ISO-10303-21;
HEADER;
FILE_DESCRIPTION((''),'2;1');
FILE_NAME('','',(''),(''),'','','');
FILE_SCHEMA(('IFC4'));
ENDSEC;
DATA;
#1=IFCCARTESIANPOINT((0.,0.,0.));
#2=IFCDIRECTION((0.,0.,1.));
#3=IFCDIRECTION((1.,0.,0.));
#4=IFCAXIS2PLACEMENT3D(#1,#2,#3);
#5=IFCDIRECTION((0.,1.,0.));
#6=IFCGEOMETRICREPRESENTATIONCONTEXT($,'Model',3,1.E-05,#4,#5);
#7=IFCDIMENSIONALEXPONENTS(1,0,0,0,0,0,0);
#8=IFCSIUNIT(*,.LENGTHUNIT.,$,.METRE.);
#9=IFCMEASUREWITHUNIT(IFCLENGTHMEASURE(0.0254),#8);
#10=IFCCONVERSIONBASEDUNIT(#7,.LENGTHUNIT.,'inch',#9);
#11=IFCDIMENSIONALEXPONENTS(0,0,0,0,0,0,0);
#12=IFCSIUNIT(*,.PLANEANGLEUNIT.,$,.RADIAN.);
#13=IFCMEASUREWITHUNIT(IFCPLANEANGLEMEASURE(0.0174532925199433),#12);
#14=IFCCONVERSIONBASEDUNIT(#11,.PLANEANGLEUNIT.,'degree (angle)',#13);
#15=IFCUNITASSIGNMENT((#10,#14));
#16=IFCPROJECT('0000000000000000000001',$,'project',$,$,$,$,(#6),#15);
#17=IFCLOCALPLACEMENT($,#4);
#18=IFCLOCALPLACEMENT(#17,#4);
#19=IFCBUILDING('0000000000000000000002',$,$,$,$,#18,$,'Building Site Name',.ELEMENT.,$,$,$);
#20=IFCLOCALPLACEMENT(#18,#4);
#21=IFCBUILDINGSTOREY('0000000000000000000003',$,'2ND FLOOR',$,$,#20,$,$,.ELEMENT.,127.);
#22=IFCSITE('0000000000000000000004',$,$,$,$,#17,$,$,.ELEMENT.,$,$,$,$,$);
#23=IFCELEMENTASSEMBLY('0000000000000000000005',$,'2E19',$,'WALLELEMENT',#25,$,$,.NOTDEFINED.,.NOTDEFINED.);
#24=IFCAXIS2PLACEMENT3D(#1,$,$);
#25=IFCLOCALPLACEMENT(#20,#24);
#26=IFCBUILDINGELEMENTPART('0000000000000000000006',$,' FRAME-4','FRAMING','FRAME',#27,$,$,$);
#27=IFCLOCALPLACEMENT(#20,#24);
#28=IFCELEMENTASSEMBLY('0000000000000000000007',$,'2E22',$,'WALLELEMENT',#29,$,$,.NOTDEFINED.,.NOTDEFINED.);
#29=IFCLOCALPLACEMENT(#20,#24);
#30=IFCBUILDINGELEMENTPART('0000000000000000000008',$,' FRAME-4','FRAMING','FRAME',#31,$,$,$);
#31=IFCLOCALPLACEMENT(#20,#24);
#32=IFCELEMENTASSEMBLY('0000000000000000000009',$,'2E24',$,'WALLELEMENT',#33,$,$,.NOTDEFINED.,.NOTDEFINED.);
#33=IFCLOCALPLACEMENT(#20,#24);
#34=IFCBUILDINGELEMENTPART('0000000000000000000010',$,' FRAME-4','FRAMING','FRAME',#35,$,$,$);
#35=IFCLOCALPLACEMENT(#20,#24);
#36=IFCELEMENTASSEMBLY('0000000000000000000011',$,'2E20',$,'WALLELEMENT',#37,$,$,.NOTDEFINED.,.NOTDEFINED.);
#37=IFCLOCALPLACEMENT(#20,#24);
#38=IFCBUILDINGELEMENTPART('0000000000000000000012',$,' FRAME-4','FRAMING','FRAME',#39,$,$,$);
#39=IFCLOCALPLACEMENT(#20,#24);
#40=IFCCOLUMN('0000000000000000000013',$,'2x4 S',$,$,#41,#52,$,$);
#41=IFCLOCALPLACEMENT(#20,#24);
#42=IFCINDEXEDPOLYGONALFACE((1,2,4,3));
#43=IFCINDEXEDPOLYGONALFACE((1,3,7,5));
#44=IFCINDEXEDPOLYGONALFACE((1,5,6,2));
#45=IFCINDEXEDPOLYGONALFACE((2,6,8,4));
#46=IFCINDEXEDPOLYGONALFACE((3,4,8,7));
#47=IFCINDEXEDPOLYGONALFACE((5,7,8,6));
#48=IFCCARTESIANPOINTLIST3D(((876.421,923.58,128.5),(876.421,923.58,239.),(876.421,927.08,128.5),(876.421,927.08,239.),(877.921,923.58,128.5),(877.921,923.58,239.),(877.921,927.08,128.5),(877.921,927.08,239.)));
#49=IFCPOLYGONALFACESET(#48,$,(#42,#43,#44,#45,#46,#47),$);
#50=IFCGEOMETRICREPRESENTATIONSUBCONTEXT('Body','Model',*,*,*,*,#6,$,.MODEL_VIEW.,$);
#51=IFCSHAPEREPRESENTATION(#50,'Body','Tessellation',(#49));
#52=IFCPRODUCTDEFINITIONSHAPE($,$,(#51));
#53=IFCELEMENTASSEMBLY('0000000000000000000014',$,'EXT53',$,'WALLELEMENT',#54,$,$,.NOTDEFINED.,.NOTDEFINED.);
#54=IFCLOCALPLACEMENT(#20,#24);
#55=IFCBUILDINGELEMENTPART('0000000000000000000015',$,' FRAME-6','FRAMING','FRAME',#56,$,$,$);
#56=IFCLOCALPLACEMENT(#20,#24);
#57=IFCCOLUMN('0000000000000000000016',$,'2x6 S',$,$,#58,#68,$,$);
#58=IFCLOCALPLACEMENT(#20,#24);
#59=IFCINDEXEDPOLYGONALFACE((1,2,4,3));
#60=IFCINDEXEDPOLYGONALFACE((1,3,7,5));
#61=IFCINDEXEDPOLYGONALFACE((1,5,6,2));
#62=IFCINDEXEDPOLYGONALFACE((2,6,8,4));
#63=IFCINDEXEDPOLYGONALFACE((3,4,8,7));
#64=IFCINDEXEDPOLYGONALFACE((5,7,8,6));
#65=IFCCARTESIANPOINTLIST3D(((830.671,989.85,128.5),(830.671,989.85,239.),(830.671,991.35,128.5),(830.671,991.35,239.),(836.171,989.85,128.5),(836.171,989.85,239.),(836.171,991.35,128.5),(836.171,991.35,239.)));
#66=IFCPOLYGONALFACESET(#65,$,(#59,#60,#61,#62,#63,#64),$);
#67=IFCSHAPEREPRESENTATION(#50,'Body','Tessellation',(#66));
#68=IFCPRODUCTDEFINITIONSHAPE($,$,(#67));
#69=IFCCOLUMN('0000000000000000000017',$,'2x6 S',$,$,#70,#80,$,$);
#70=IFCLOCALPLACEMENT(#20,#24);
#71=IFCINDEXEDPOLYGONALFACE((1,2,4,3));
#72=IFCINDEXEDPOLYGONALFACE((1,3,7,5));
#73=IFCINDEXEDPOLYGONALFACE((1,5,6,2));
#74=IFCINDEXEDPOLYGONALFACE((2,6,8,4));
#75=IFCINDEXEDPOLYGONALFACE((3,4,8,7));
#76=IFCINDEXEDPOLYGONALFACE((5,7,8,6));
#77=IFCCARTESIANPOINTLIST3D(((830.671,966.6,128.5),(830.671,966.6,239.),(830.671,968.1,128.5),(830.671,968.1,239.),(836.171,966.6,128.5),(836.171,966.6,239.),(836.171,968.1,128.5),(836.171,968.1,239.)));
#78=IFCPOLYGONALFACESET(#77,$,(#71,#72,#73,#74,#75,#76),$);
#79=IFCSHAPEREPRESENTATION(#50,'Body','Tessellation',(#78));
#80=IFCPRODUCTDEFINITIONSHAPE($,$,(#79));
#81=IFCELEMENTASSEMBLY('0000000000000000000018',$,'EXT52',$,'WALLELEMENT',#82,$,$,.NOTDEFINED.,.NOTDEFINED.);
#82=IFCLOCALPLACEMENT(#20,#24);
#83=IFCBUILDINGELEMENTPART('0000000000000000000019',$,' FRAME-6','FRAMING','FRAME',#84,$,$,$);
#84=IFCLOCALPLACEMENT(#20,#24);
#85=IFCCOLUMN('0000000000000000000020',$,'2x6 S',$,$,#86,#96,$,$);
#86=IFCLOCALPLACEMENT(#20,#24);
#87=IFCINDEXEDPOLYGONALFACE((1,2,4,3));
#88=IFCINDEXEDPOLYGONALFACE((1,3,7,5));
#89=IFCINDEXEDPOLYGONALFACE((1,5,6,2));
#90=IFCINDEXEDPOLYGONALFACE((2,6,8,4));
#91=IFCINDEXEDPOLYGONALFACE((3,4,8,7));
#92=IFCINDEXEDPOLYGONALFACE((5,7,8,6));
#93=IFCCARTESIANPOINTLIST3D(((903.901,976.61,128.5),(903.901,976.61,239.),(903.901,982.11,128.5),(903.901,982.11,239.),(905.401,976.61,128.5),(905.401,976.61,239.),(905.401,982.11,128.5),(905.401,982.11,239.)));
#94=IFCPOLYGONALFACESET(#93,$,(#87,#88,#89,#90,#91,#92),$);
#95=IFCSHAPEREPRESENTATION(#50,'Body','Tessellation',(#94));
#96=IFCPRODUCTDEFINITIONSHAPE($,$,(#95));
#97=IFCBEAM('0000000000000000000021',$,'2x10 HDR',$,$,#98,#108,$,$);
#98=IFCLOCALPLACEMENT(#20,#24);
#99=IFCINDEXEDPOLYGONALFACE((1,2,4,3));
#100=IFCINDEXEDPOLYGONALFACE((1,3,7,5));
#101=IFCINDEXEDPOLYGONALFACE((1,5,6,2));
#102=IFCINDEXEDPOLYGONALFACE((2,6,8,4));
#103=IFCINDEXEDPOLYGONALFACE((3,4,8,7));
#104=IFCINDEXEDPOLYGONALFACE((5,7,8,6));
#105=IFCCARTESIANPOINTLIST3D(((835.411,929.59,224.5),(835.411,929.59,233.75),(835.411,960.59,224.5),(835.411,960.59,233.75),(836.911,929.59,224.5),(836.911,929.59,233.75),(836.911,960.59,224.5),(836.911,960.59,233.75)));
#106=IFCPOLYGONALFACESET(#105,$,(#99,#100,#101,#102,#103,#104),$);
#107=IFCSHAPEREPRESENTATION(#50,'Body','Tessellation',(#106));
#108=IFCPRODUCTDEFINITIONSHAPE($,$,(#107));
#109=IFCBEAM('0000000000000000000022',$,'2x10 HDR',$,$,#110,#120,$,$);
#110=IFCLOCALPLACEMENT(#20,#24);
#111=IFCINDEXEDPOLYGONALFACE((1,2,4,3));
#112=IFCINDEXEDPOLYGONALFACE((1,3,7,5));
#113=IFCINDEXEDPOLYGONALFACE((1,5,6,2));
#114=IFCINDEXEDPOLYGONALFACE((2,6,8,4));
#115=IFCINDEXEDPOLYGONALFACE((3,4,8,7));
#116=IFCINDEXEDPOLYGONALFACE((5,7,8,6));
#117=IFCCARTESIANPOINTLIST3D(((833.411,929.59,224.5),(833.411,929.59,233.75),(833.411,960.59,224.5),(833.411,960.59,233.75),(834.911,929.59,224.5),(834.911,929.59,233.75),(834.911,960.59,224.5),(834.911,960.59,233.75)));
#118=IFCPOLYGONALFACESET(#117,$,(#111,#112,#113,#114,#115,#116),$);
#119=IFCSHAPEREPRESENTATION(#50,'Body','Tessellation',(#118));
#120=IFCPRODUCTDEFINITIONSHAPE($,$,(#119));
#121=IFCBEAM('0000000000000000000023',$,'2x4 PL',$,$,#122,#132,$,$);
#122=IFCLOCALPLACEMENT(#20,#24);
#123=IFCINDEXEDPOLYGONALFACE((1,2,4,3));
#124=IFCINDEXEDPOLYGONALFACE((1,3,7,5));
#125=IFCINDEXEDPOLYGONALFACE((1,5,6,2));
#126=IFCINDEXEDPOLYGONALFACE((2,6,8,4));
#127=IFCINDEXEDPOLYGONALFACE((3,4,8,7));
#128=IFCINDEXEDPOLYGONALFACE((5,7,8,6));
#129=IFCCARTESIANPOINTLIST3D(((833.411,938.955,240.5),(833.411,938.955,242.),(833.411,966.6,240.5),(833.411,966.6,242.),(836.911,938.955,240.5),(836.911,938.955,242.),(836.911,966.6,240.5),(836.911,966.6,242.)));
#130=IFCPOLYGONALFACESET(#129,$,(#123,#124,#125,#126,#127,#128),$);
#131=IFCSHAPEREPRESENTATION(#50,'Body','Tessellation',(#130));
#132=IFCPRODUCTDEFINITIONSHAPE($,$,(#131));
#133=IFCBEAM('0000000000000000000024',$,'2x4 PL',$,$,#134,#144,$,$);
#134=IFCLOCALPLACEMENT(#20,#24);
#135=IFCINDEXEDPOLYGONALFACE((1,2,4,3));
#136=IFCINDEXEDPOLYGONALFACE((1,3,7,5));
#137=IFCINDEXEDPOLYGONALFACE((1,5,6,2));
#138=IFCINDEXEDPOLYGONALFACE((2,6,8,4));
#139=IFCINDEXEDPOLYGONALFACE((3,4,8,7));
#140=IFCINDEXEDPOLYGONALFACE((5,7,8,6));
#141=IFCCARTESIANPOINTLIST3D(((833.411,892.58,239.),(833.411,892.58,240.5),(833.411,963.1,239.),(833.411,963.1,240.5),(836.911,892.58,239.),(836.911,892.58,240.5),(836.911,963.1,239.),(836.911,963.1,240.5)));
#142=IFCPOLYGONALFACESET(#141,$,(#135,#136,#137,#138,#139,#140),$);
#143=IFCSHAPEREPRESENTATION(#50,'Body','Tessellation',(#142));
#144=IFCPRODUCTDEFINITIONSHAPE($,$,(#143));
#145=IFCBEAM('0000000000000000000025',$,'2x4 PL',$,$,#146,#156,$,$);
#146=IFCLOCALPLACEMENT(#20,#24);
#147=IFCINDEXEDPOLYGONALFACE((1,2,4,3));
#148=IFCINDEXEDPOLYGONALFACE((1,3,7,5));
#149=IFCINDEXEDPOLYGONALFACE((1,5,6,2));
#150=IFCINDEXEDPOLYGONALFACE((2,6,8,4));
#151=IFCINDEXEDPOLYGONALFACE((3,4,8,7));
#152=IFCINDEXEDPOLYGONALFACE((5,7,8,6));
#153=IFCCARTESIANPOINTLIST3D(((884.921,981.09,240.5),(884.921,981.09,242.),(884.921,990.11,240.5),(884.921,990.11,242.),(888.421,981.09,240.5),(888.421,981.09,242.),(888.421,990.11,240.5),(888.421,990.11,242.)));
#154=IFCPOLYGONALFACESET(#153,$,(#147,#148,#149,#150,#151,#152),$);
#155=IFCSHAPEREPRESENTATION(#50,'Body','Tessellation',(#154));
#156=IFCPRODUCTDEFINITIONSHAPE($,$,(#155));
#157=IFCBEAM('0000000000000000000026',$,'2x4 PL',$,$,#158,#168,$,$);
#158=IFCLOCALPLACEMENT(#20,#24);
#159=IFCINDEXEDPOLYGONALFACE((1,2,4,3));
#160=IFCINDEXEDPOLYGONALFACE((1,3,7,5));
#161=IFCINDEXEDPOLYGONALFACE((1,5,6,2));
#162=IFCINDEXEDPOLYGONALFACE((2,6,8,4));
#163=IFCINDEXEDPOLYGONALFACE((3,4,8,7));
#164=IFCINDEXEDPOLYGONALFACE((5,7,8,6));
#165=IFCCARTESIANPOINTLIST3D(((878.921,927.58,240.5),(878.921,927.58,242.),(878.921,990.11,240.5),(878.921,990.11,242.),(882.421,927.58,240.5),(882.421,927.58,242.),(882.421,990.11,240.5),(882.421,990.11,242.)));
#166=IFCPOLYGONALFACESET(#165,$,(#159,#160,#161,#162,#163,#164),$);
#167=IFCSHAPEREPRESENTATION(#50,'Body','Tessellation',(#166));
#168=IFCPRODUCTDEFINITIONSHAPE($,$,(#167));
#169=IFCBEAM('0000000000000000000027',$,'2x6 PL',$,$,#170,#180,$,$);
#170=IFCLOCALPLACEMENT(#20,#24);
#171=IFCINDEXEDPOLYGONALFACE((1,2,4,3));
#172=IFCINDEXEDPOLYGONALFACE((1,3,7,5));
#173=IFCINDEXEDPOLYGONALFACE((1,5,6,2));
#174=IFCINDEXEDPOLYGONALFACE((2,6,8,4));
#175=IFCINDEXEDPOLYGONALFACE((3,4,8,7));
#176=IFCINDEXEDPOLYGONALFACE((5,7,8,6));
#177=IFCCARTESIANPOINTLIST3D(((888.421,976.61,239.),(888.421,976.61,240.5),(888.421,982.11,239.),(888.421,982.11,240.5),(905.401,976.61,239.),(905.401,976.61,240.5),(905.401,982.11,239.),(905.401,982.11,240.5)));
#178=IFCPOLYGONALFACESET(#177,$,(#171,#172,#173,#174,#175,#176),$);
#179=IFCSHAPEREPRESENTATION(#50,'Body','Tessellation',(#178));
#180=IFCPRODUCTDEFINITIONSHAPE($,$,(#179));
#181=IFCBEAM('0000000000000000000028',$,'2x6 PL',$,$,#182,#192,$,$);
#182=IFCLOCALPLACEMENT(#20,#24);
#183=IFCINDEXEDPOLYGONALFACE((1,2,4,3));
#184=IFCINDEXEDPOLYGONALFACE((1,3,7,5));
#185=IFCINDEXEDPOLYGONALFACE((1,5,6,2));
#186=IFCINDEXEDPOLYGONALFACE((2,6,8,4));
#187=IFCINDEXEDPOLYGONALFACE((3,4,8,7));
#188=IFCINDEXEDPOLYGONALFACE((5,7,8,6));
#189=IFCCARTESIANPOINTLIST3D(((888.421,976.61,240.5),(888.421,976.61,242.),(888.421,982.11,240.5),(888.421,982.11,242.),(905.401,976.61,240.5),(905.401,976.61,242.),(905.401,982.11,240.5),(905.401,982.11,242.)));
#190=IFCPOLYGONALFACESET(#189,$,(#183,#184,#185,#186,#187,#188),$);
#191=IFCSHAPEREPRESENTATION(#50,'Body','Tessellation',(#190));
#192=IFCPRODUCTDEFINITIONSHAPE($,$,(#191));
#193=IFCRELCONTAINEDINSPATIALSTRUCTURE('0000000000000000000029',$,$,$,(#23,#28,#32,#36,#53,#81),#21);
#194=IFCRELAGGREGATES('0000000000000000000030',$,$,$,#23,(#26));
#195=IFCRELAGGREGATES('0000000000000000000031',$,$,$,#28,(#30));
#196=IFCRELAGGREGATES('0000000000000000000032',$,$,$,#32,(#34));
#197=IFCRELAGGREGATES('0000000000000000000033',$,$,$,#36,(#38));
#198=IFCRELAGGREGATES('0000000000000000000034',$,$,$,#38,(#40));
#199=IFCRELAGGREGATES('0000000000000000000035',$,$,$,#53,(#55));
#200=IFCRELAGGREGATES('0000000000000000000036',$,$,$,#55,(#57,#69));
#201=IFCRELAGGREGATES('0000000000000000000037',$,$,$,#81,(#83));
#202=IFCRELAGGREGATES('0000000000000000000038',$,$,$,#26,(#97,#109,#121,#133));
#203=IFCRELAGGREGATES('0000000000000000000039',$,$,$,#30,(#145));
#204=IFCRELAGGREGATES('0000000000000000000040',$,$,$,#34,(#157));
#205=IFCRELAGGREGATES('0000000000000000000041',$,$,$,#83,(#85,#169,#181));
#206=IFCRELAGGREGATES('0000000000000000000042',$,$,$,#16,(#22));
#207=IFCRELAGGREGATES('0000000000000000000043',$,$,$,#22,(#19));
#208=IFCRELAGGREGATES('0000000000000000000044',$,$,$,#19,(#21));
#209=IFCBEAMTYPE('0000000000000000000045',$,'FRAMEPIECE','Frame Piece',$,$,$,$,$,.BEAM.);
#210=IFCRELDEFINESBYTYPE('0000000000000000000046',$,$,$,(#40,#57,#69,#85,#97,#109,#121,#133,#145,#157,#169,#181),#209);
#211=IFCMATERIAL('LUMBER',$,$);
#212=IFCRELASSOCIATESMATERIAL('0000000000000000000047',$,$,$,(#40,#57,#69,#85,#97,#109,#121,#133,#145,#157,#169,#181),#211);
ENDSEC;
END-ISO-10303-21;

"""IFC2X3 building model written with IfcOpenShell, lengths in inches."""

from ifc_helpers import new_model, entity, si_unit, converted_unit, direction, frame, frame_2d, origin_with_axes, place, context, subcontext, project, spatial, rectangle, extrude, material, type_object, element, aggregate, save


model = new_model("IFC2X3")

# Units and contexts
model_context = context("Model", 3, precision=1e-05, world=origin_with_axes(), true_north=direction((0.0, 1.0, 0.0)))
body_context = subcontext(model_context, "Body", "Model", "MODEL_VIEW")
ifc_project = project(units=[converted_unit("LENGTHUNIT", "inch", entity("IfcLengthMeasure", 0.0254), si_unit("LENGTHUNIT", "METRE"), dimensions=[1, 0, 0, 0, 0, 0, 0]), converted_unit("PLANEANGLEUNIT", "degree (angle)", entity("IfcPlaneAngleMeasure", 0.0174532925199433), si_unit("PLANEANGLEUNIT", "RADIAN"), dimensions=[0, 0, 0, 0, 0, 0, 0])], contexts=[model_context])

# Site, building, storey
site_placement = place(None, origin_with_axes())
site = spatial("IfcSite", under=ifc_project, at=site_placement, CompositionType="ELEMENT")
building_placement = place(site_placement, origin_with_axes())
building = spatial("IfcBuilding", under=site, at=building_placement, LongName="Building Site Name", CompositionType="ELEMENT")
storey_placement = place(building_placement, origin_with_axes())
storey = spatial("IfcBuildingStorey", under=building, at=storey_placement, Name="2ND FLOOR", CompositionType="ELEMENT", Elevation=127.0)

# Element assembly, building element part
assembly_1_placement = place(storey_placement, origin_with_axes())
assembly_1 = element("IfcElementAssembly", 1, at=assembly_1_placement, inside=storey, Name="2E19", ObjectType="WALLELEMENT", AssemblyPlace="NOTDEFINED", PredefinedType="NOTDEFINED")
building_element_part_1 = element("IfcBuildingElementPart", 2, Name=" FRAME-4", Description="FRAMING", ObjectType="FRAME")
aggregate(assembly_1, [building_element_part_1])
ifc_material = material(Name="LUMBER")
beam_type = type_object("IfcBeamType", Name="FRAMEPIECE", Description="Frame Piece", PredefinedType="BEAM")

# Element assembly, building element part
assembly_2_placement = place(storey_placement, origin_with_axes())
assembly_2 = element("IfcElementAssembly", 3, at=assembly_2_placement, inside=storey, Name="2E22", ObjectType="WALLELEMENT", AssemblyPlace="NOTDEFINED", PredefinedType="NOTDEFINED")
building_element_part_2 = element("IfcBuildingElementPart", 4, Name=" FRAME-4", Description="FRAMING", ObjectType="FRAME")
aggregate(assembly_2, [building_element_part_2])

# Element assemblies, building element parts, columns
assembly_3_placement = place(storey_placement, origin_with_axes())
assembly_3 = element("IfcElementAssembly", 5, at=assembly_3_placement, inside=storey, Name="2E24", ObjectType="WALLELEMENT", AssemblyPlace="NOTDEFINED", PredefinedType="NOTDEFINED")
building_element_part_3 = element("IfcBuildingElementPart", 6, Name=" FRAME-4", Description="FRAMING", ObjectType="FRAME")
aggregate(assembly_3, [building_element_part_3])
assembly_4_placement = place(storey_placement, origin_with_axes())
assembly_4 = element("IfcElementAssembly", 7, at=assembly_4_placement, inside=storey, Name="2E20", ObjectType="WALLELEMENT", AssemblyPlace="NOTDEFINED", PredefinedType="NOTDEFINED")
building_element_part_4 = element("IfcBuildingElementPart", 8, Name=" FRAME-4", Description="FRAMING", ObjectType="FRAME")
aggregate(assembly_4, [building_element_part_4])
column_1_placement = place(assembly_4_placement, frame((877.171, 925.33, 239.0), z_axis=(0.0, 0.0, -1.0), x_axis=(-1.0, 0.0, 0.0)))
column_1 = element("IfcColumn", 9, at=column_1_placement, type_object=beam_type, material=ifc_material, Name="2x4 S", context=body_context, shape_type="SweptSolid", body=[
    extrude(rectangle(XDim=1.5, YDim=3.5, at=frame_2d((0.0, 0.0), x_axis=(-1.0, 0.0))), origin_with_axes(), (0.0, 0.0, 1.0), 110.5),
])
aggregate(building_element_part_4, [column_1])
assembly_5_placement = place(storey_placement, origin_with_axes())
assembly_5 = element("IfcElementAssembly", 10, at=assembly_5_placement, inside=storey, Name="EXT53", ObjectType="WALLELEMENT", AssemblyPlace="NOTDEFINED", PredefinedType="NOTDEFINED")
building_element_part_5 = element("IfcBuildingElementPart", 11, Name=" FRAME-6", Description="FRAMING", ObjectType="FRAME")
aggregate(assembly_5, [building_element_part_5])
column_2_placement = place(assembly_5_placement, frame((833.421, 990.6, 239.0), z_axis=(0.0, 0.0, -1.0), x_axis=(0.0, 1.0, 0.0)))
column_2 = element("IfcColumn", 12, at=column_2_placement, type_object=beam_type, material=ifc_material, Name="2x6 S", context=body_context, shape_type="SweptSolid", body=[
    extrude(rectangle(XDim=1.5, YDim=5.5, at=frame_2d((0.0, 0.0), x_axis=(-1.0, 0.0))), origin_with_axes(), (0.0, 0.0, 1.0), 110.5),
])
column_3_placement = place(assembly_5_placement, frame((833.421, 967.35, 239.0), z_axis=(0.0, 0.0, -1.0), x_axis=(0.0, 1.0, 0.0)))
column_3 = element("IfcColumn", 13, at=column_3_placement, type_object=beam_type, material=ifc_material, Name="2x6 S", context=body_context, shape_type="SweptSolid", body=[
    extrude(rectangle(XDim=1.5, YDim=5.5, at=frame_2d((0.0, 0.0), x_axis=(-1.0, 0.0))), origin_with_axes(), (0.0, 0.0, 1.0), 110.5),
])
aggregate(building_element_part_5, [column_2, column_3])

# Element assembly, building element part, column
assembly_6_placement = place(storey_placement, origin_with_axes())
assembly_6 = element("IfcElementAssembly", 14, at=assembly_6_placement, inside=storey, Name="EXT52", ObjectType="WALLELEMENT", AssemblyPlace="NOTDEFINED", PredefinedType="NOTDEFINED")
building_element_part_6 = element("IfcBuildingElementPart", 15, Name=" FRAME-6", Description="FRAMING", ObjectType="FRAME")
aggregate(assembly_6, [building_element_part_6])
column_4_placement = place(assembly_6_placement, frame((904.651, 979.36, 239.0), z_axis=(0.0, 0.0, -1.0), x_axis=(-1.0, 0.0, 0.0)))
column_4 = element("IfcColumn", 16, at=column_4_placement, type_object=beam_type, material=ifc_material, Name="2x6 S", context=body_context, shape_type="SweptSolid", body=[
    extrude(rectangle(XDim=1.5, YDim=5.5, at=frame_2d((0.0, 0.0), x_axis=(-1.0, 0.0))), origin_with_axes(), (0.0, 0.0, 1.0), 110.5),
])

# Beams
beam_1_placement = place(assembly_1_placement, frame((836.161, 929.59, 229.125), z_axis=(0.0, 1.0, 0.0), x_axis=(-1.0, 0.0, 0.0)))
beam_1 = element("IfcBeam", 17, at=beam_1_placement, type_object=beam_type, material=ifc_material, Name="2x10 HDR", context=body_context, shape_type="SweptSolid", body=[
    extrude(rectangle(XDim=1.5, YDim=9.25, at=frame_2d((0.0, 0.0), x_axis=(-1.0, 0.0))), origin_with_axes(), (0.0, 0.0, 1.0), 31.0),
])
beam_2_placement = place(assembly_1_placement, frame((834.161, 929.59, 229.125), z_axis=(0.0, 1.0, 0.0), x_axis=(-1.0, 0.0, 0.0)))
beam_2 = element("IfcBeam", 18, at=beam_2_placement, type_object=beam_type, material=ifc_material, Name="2x10 HDR", context=body_context, shape_type="SweptSolid", body=[
    extrude(rectangle(XDim=1.5, YDim=9.25, at=frame_2d((0.0, 0.0), x_axis=(-1.0, 0.0))), origin_with_axes(), (0.0, 0.0, 1.0), 31.0),
])
beam_3_placement = place(assembly_1_placement, frame((835.161, 966.6, 241.25), z_axis=(0.0, -1.0, 0.0), x_axis=(0.0, 0.0, -1.0)))
beam_3 = element("IfcBeam", 19, at=beam_3_placement, type_object=beam_type, material=ifc_material, Name="2x4 PL", context=body_context, shape_type="SweptSolid", body=[
    extrude(rectangle(XDim=1.5, YDim=3.5, at=frame_2d((0.0, 0.0), x_axis=(-1.0, 0.0))), origin_with_axes(), (0.0, 0.0, 1.0), 27.645),
])
beam_4_placement = place(assembly_1_placement, frame((835.161, 963.1, 239.75), z_axis=(0.0, -1.0, 0.0), x_axis=(0.0, 0.0, -1.0)))
beam_4 = element("IfcBeam", 20, at=beam_4_placement, type_object=beam_type, material=ifc_material, Name="2x4 PL", context=body_context, shape_type="SweptSolid", body=[
    extrude(rectangle(XDim=1.5, YDim=3.5, at=frame_2d((0.0, 0.0), x_axis=(-1.0, 0.0))), origin_with_axes(), (0.0, 0.0, 1.0), 70.52),
])
aggregate(building_element_part_1, [beam_1, beam_2, beam_3, beam_4])
beam_5_placement = place(assembly_2_placement, frame((886.671, 990.11, 241.25), z_axis=(0.0, -1.0, 0.0), x_axis=(0.0, 0.0, -1.0)))
beam_5 = element("IfcBeam", 21, at=beam_5_placement, type_object=beam_type, material=ifc_material, Name="2x4 PL", context=body_context, shape_type="SweptSolid", body=[
    extrude(rectangle(XDim=1.5, YDim=3.5, at=frame_2d((0.0, 0.0), x_axis=(-1.0, 0.0))), origin_with_axes(), (0.0, 0.0, 1.0), 9.02),
])
aggregate(building_element_part_2, [beam_5])
beam_6_placement = place(assembly_3_placement, frame((880.671, 990.11, 241.25), z_axis=(0.0, -1.0, 0.0), x_axis=(0.0, 0.0, -1.0)))
beam_6 = element("IfcBeam", 22, at=beam_6_placement, type_object=beam_type, material=ifc_material, Name="2x4 PL", context=body_context, shape_type="SweptSolid", body=[
    extrude(rectangle(XDim=1.5, YDim=3.5, at=frame_2d((0.0, 0.0), x_axis=(-1.0, 0.0))), origin_with_axes(), (0.0, 0.0, 1.0), 62.53),
])
aggregate(building_element_part_3, [beam_6])
beam_7_placement = place(assembly_6_placement, frame((888.421, 979.36, 239.75), z_axis=(1.0, 0.0, 0.0), x_axis=(0.0, 0.0, -1.0)))
beam_7 = element("IfcBeam", 23, at=beam_7_placement, type_object=beam_type, material=ifc_material, Name="2x6 PL", context=body_context, shape_type="SweptSolid", body=[
    extrude(rectangle(XDim=1.5, YDim=5.5, at=frame_2d((0.0, 0.0), x_axis=(-1.0, 0.0))), frame((0.0, 0.0, 0.0), z_axis=(0.0, 0.0, 1.0), x_axis=(1.0, 0.0, 0.0)), (0.0, 0.0, 1.0), 16.98),
])
beam_8_placement = place(assembly_6_placement, frame((888.421, 979.36, 241.25), z_axis=(1.0, 0.0, 0.0), x_axis=(0.0, 0.0, -1.0)))
beam_8 = element("IfcBeam", 24, at=beam_8_placement, type_object=beam_type, material=ifc_material, Name="2x6 PL", context=body_context, shape_type="SweptSolid", body=[
    extrude(rectangle(XDim=1.5, YDim=5.5, at=frame_2d((0.0, 0.0), x_axis=(-1.0, 0.0))), origin_with_axes(), (0.0, 0.0, 1.0), 16.98),
])
aggregate(building_element_part_6, [column_4, beam_7, beam_8])

save(model, "model.ifc")
